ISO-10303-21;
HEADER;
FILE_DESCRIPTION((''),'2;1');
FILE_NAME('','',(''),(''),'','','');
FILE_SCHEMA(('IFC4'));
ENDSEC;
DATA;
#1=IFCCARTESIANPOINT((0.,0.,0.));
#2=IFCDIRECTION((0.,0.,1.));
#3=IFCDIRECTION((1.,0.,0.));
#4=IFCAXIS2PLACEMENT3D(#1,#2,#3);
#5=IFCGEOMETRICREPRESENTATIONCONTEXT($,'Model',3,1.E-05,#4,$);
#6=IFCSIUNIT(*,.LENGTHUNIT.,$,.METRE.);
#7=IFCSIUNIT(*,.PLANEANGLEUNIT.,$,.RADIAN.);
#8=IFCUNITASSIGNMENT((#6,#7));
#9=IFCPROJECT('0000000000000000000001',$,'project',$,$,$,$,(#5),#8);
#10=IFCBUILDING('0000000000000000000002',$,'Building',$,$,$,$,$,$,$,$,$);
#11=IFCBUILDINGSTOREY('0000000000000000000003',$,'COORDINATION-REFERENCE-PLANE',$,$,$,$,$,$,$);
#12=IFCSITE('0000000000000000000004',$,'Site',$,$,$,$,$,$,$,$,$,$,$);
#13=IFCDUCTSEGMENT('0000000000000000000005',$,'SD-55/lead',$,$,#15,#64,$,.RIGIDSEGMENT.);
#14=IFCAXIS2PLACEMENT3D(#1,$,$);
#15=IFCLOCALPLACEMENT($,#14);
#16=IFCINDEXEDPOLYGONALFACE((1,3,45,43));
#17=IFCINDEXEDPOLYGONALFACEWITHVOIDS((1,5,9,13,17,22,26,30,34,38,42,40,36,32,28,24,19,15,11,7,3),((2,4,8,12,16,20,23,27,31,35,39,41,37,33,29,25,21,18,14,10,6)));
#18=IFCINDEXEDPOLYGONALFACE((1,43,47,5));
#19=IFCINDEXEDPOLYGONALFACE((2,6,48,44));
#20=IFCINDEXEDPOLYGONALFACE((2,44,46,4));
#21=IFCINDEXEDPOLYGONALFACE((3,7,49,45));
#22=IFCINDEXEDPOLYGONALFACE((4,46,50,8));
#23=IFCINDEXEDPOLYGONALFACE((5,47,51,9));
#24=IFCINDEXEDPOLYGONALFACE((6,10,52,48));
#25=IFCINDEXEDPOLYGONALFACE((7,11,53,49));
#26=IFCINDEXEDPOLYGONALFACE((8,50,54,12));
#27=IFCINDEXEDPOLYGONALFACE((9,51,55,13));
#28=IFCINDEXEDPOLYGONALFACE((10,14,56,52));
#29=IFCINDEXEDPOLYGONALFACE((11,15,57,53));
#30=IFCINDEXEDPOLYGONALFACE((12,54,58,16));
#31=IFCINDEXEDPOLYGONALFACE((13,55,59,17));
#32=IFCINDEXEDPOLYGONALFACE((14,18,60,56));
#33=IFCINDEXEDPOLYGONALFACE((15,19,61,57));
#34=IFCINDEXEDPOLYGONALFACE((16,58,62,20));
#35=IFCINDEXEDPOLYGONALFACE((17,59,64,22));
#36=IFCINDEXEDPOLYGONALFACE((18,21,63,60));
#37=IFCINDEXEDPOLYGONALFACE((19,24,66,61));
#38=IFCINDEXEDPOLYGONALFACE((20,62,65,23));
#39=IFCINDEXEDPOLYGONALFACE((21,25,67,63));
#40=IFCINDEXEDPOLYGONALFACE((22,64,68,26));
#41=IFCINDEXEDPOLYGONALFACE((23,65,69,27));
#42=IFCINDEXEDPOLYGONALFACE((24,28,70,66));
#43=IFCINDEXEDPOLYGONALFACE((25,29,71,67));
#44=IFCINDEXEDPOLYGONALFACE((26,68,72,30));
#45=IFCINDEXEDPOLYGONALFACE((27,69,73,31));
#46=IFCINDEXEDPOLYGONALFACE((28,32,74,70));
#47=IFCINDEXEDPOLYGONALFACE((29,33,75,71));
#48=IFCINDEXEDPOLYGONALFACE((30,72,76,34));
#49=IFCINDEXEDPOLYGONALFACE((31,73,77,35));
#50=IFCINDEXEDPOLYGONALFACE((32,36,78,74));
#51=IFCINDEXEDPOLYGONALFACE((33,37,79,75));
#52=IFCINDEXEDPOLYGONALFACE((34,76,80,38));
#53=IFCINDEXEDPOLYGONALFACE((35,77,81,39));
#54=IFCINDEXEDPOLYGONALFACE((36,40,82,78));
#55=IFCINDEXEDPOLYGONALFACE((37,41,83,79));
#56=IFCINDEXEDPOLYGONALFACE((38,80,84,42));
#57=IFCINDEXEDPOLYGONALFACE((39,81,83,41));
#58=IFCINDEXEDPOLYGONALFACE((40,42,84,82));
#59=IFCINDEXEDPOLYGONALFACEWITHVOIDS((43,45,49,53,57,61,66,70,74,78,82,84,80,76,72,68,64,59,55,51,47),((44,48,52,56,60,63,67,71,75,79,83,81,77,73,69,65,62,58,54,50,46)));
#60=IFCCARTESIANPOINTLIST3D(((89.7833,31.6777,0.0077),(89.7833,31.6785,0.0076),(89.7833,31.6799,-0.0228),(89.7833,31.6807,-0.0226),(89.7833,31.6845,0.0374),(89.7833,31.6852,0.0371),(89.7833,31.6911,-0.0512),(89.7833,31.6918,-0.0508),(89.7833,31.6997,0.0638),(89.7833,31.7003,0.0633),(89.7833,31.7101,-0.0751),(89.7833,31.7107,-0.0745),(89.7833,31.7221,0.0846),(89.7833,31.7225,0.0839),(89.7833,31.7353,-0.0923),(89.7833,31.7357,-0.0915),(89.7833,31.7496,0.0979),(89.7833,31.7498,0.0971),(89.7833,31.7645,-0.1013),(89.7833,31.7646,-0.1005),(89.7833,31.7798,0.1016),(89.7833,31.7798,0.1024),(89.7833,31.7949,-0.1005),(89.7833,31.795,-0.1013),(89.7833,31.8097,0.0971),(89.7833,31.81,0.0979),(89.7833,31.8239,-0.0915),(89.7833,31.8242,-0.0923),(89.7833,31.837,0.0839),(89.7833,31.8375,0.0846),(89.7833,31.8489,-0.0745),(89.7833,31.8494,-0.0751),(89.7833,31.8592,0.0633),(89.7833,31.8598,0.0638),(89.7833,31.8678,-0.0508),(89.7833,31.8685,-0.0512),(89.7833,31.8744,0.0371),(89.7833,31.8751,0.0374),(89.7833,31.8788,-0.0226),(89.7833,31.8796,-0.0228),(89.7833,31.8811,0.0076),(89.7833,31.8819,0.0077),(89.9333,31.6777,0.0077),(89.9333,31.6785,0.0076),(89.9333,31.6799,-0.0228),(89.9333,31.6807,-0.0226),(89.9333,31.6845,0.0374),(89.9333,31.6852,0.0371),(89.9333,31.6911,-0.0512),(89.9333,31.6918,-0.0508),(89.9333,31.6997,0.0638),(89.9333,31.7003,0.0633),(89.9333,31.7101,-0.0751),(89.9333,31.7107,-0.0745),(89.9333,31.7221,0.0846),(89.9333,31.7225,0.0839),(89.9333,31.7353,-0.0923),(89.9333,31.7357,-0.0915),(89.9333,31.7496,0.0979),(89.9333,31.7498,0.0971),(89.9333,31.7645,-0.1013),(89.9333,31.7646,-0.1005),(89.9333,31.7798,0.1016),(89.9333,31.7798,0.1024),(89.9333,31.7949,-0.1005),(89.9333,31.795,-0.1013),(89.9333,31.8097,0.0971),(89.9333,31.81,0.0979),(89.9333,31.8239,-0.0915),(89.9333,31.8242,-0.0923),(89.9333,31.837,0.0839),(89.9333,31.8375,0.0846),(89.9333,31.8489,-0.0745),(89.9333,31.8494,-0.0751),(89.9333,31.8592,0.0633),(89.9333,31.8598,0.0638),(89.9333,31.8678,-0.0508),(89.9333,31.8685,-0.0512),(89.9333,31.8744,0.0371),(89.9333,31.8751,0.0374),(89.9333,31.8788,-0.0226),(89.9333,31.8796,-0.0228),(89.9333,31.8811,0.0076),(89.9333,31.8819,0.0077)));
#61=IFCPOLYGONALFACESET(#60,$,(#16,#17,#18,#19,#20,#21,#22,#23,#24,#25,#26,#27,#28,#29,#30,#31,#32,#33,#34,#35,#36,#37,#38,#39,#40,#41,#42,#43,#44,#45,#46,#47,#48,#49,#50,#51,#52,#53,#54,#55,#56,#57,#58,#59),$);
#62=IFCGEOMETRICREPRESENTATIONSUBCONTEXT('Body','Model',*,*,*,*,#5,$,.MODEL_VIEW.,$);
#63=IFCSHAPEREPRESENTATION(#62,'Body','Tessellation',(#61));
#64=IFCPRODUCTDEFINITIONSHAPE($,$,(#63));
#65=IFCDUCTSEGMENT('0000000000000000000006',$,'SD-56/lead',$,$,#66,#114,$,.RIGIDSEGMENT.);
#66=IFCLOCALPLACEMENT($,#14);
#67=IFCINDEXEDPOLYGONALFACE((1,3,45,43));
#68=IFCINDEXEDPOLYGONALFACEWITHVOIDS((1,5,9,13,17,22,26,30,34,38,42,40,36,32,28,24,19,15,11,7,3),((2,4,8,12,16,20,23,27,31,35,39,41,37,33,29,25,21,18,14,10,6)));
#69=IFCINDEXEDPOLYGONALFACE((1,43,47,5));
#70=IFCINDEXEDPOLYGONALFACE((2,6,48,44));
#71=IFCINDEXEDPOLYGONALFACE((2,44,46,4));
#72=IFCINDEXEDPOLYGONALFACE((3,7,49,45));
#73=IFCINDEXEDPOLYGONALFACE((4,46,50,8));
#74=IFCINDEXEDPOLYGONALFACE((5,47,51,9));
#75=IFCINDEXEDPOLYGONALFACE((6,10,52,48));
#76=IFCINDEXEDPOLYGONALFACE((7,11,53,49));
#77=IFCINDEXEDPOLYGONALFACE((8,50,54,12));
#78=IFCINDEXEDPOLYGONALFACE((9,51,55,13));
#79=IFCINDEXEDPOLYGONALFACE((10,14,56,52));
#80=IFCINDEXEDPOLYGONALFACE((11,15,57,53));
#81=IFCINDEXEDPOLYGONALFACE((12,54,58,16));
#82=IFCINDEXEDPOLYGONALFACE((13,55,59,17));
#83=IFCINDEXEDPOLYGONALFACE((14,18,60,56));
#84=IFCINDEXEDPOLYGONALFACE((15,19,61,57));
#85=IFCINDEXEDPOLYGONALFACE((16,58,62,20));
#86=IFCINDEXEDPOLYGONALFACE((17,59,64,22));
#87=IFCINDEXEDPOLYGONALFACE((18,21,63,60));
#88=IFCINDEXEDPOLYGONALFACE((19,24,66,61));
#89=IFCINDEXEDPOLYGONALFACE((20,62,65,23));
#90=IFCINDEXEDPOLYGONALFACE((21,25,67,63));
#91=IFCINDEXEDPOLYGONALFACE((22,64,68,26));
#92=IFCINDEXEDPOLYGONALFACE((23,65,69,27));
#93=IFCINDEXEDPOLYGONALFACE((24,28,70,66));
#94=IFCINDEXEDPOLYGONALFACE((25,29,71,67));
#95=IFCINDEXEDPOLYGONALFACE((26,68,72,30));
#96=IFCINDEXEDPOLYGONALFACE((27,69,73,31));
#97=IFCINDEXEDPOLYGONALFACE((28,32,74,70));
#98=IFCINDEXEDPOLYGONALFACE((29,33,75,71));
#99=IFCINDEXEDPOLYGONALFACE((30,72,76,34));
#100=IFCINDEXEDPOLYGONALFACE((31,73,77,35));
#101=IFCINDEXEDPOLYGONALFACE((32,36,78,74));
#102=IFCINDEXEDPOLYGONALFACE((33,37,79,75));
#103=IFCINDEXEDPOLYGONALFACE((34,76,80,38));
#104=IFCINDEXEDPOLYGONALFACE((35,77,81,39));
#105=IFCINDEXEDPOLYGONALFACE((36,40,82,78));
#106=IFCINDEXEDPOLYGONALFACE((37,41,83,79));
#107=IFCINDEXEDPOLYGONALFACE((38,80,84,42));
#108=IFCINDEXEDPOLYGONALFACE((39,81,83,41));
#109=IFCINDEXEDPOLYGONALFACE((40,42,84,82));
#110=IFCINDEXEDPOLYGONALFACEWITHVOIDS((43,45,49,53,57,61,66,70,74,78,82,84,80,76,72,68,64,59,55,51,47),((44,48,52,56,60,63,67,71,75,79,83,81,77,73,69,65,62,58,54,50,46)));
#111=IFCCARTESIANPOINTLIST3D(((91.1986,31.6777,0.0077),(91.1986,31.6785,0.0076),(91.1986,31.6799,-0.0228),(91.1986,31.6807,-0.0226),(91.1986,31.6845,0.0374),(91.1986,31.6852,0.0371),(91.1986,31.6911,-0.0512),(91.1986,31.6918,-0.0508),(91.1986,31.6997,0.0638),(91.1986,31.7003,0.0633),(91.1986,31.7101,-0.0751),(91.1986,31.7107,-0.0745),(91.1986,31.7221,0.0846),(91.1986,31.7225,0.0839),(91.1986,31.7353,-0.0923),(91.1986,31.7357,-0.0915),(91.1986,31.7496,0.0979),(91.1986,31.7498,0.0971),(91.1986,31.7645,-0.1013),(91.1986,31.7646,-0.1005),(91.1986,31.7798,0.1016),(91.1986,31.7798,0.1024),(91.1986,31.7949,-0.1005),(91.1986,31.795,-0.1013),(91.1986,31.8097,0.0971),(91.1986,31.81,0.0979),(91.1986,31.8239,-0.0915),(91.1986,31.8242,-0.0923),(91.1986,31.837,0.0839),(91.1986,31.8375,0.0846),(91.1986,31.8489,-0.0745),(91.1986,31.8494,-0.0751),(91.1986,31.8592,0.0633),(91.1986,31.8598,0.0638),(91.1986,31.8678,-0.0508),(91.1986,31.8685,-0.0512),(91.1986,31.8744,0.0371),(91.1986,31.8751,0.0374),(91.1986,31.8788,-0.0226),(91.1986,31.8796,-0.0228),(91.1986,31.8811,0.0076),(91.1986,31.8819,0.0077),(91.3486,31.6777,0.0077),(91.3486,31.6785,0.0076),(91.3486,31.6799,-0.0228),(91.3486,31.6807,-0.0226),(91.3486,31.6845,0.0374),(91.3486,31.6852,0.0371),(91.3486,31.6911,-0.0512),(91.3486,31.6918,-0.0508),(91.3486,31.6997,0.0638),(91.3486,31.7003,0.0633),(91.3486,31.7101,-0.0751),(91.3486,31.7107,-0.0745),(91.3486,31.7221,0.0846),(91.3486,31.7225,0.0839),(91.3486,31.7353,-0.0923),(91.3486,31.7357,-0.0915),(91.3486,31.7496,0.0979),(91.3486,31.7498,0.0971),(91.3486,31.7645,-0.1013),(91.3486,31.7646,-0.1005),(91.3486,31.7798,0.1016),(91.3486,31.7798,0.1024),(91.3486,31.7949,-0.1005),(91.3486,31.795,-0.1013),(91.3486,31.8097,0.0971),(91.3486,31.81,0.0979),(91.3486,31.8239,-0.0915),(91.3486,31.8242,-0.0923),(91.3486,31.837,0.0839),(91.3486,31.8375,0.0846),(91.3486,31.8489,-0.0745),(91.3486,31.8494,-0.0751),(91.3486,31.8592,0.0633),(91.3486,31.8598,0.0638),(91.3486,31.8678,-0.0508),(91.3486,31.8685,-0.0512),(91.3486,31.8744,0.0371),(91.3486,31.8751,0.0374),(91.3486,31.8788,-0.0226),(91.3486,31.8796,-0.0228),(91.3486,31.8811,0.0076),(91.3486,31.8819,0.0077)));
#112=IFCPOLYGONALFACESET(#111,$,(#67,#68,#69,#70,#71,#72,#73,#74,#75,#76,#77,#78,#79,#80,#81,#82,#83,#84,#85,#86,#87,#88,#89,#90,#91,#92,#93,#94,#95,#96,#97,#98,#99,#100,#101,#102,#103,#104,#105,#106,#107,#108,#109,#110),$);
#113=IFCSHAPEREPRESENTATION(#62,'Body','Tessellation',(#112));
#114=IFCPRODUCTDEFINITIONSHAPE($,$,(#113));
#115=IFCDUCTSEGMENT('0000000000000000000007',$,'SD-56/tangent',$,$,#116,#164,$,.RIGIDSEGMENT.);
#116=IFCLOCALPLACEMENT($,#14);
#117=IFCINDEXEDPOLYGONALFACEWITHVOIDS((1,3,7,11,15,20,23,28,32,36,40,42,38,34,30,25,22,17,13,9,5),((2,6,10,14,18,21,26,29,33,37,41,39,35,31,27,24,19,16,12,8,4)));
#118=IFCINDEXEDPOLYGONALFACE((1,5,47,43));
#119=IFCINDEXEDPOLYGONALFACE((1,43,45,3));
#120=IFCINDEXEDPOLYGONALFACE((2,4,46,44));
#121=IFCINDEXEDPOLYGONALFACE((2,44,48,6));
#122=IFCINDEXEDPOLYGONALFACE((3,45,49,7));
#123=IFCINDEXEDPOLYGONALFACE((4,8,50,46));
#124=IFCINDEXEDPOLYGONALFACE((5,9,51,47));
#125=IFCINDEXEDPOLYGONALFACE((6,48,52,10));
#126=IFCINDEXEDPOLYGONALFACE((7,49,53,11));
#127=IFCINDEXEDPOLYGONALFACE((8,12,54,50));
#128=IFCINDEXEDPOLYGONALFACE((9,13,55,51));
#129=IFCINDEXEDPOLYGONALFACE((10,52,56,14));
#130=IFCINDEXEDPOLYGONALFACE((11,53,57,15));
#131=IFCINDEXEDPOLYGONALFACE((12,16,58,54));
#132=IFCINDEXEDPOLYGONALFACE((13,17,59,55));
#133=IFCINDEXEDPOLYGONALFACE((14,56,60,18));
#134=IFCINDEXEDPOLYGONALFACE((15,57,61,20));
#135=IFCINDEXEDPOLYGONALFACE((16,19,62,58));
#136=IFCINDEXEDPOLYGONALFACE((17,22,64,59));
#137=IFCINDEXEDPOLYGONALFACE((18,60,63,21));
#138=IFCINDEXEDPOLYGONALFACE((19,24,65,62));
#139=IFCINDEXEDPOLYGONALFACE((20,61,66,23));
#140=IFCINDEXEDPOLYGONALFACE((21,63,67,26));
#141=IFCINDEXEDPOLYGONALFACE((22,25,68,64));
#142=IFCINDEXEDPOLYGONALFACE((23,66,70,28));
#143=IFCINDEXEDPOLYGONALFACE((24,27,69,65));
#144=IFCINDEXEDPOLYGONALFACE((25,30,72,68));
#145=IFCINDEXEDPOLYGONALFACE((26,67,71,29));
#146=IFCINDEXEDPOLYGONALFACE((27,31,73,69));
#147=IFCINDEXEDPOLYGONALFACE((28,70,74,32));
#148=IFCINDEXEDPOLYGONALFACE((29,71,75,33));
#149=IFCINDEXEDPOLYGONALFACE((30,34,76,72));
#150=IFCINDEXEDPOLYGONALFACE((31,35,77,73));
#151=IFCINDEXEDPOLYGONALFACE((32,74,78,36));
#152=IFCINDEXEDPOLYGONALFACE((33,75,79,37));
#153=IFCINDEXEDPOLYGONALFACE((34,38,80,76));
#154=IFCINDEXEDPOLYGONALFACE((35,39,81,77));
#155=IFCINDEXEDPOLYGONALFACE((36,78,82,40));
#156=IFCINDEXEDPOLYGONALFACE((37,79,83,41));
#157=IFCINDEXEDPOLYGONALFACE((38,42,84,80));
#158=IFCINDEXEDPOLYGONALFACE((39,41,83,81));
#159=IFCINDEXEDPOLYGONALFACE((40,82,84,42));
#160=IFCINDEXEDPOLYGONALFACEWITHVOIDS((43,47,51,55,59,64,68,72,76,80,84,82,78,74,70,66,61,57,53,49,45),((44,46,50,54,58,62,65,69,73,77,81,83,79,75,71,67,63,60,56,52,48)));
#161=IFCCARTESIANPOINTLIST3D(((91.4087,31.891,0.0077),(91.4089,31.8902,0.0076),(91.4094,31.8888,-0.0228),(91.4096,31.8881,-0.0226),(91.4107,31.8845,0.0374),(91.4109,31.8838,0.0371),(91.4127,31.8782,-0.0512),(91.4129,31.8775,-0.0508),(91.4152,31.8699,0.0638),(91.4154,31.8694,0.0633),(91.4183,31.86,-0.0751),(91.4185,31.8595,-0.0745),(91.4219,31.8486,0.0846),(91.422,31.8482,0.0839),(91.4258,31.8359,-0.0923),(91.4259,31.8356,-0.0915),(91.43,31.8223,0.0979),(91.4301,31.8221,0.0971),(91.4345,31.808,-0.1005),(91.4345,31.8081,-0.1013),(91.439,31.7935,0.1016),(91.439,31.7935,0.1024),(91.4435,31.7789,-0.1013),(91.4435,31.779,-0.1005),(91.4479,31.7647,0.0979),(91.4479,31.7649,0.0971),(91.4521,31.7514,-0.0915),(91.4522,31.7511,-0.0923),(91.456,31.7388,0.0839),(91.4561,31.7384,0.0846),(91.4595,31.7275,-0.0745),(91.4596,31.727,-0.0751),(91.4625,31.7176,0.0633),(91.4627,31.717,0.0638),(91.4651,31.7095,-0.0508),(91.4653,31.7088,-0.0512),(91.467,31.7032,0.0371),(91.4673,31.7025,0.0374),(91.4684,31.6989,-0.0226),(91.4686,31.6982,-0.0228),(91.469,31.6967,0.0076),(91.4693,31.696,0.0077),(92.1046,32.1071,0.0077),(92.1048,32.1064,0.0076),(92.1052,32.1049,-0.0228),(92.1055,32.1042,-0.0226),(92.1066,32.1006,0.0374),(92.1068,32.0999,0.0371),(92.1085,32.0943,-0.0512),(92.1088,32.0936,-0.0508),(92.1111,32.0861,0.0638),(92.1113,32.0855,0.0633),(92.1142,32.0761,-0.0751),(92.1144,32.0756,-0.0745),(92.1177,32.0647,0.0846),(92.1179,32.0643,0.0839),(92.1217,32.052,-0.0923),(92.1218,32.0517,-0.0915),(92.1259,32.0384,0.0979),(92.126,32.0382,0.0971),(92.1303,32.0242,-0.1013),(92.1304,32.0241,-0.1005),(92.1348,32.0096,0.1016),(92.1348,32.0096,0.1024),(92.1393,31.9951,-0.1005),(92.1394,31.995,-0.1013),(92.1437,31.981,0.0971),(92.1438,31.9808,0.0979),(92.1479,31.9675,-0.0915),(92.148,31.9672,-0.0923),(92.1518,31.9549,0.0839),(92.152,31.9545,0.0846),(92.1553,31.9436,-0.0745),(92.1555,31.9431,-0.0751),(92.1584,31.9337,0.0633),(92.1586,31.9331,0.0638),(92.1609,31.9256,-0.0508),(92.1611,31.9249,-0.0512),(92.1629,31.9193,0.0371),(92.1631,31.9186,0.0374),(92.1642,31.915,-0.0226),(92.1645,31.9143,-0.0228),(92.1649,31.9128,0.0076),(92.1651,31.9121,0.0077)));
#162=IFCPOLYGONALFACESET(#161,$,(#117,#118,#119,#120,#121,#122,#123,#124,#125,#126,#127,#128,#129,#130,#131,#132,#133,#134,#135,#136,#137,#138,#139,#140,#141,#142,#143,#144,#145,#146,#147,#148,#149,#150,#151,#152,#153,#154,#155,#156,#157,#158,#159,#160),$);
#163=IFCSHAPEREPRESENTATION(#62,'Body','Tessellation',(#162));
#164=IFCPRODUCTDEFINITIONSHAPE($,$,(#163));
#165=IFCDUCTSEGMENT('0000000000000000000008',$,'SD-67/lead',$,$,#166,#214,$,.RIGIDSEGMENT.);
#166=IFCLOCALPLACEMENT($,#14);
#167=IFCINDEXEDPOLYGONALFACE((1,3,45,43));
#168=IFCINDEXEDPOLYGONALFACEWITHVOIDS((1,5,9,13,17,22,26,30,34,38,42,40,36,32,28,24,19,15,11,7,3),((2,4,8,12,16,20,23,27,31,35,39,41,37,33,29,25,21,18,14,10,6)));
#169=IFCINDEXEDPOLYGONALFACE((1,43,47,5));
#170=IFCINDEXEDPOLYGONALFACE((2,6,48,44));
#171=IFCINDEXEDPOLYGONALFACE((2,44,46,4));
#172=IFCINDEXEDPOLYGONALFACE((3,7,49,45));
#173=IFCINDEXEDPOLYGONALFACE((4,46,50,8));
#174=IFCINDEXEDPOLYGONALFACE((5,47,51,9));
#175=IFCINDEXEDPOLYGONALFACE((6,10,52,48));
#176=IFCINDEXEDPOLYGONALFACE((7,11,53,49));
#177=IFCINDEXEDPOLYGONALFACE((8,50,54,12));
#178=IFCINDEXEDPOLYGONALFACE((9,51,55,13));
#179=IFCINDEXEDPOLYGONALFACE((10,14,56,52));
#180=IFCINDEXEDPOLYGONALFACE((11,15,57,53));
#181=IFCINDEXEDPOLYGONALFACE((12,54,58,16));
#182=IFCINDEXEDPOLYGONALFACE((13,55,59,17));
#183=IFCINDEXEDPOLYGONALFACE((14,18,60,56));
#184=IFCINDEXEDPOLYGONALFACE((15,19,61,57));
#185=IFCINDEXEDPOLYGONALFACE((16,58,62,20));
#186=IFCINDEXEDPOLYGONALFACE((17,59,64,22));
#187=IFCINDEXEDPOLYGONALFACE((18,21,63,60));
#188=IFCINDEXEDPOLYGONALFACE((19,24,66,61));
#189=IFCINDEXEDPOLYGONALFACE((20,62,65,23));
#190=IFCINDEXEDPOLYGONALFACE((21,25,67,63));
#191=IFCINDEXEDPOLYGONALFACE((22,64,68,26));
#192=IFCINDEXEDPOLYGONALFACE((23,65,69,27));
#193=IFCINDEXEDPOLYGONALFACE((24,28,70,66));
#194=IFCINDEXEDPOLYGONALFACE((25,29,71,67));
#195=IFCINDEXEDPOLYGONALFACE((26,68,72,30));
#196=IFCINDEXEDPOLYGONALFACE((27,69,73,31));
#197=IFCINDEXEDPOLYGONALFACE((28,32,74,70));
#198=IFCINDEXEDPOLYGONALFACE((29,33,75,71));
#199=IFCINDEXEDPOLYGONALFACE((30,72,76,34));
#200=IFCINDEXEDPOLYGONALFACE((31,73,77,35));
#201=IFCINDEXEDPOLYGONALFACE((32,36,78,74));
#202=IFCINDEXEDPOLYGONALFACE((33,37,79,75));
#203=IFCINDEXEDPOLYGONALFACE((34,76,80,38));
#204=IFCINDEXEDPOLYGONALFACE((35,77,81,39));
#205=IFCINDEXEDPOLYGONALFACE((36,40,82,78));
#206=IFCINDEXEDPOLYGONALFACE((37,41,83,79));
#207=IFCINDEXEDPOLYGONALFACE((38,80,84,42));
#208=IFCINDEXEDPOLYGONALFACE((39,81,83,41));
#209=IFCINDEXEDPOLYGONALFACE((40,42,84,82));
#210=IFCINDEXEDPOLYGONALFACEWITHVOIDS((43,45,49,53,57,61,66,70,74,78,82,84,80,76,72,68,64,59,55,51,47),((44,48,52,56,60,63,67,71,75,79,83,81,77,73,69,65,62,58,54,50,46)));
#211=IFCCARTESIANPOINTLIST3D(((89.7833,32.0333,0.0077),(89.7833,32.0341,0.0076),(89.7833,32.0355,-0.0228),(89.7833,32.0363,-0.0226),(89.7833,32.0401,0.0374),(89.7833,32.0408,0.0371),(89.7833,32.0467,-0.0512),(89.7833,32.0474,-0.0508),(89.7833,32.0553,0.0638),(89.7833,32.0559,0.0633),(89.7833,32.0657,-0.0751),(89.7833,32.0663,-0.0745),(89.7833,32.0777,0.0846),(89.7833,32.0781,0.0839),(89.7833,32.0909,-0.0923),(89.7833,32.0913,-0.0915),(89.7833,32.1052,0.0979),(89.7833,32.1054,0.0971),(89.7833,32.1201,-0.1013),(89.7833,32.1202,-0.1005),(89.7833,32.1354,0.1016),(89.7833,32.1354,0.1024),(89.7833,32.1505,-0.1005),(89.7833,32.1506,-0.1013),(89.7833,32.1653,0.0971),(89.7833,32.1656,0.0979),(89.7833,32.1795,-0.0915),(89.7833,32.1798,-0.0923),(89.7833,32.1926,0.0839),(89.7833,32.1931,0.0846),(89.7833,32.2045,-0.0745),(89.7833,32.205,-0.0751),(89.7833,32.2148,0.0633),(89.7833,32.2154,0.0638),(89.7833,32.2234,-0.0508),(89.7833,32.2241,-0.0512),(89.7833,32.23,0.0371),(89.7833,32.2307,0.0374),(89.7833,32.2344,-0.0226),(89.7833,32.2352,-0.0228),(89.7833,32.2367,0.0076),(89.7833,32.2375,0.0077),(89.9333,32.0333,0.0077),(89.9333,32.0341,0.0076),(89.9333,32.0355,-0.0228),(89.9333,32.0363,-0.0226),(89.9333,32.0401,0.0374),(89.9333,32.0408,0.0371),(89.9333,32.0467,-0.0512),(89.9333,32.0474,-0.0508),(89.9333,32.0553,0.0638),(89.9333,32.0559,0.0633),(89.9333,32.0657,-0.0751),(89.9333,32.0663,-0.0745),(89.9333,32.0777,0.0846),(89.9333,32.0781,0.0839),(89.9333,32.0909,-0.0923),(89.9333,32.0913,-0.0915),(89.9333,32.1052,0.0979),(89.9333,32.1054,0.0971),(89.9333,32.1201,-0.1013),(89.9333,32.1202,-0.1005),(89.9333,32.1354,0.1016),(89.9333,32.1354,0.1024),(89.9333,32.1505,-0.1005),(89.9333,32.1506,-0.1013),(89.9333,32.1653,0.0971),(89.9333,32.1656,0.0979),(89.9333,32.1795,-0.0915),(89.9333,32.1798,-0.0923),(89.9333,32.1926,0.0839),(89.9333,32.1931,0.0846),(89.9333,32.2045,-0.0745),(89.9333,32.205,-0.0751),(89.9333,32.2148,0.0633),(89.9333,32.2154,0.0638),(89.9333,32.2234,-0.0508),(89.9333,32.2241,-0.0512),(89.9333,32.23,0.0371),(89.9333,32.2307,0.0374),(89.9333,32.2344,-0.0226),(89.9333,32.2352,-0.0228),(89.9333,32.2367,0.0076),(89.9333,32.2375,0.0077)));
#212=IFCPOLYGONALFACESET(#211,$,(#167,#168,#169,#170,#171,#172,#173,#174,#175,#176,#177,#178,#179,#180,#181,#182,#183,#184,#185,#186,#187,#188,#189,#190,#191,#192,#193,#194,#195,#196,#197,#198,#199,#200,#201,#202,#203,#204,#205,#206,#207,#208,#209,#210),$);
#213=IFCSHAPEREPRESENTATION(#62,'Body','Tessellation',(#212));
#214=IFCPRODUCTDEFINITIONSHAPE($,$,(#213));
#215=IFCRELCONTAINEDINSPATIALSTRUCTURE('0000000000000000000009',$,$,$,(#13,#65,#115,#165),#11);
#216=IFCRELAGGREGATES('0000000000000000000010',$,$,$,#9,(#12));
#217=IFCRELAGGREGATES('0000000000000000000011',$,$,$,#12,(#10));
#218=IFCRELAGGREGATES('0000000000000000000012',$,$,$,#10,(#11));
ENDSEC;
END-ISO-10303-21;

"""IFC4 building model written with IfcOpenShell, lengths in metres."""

from ifc_helpers import new_model, si_unit, frame, origin_with_axes, place, context, subcontext, project, spatial, hollow_circle, extrude, element, save


model = new_model("IFC4")

# Units and contexts
model_context = context("Model", 3, precision=1e-05, world=origin_with_axes())
body_context_1 = subcontext(model_context, "Body", "Model", "MODEL_VIEW")
ifc_project = project(units=[si_unit("LENGTHUNIT", "METRE"), si_unit("PLANEANGLEUNIT", "RADIAN")], contexts=[model_context])

# Site, building, storey
site = spatial("IfcSite", under=ifc_project, Name="Site")
building = spatial("IfcBuilding", under=site, Name="Building")
storey = spatial("IfcBuildingStorey", under=building, Name="COORDINATION-REFERENCE-PLANE")

# Duct segments
for number, where, z_axis, x_axis, name in (
    (1, (89.9333, 31.7798, 0.0), (-1.0, 0.0, 0.0), (0.0, 0.0, 1.0), "SD-55/lead"),
    (2, (91.1986, 31.7798, 0.0), (1.0, 0.0, 0.0), (0.0, 0.0, 1.0), "SD-56/lead"),
):
    element("IfcDuctSegment", number, at=place(None, frame(where, z_axis=z_axis, x_axis=x_axis)), inside=storey, Name=name, PredefinedType="RIGIDSEGMENT", context=body_context_1, shape_type="SweptSolid", body=[
        extrude(hollow_circle(Radius=0.1024, WallThickness=0.0008), origin_with_axes(), (0.0, 0.0, 1.0), 0.15),
    ])

# Duct segment
duct_segment_1_placement = place(None, frame((91.439, 31.7935, 0.0), z_axis=(0.955005, 0.296589, 0.0), x_axis=(0.0, 0.0, 1.0)))
element("IfcDuctSegment", 3, at=duct_segment_1_placement, inside=storey, Name="SD-56/tangent", PredefinedType="RIGIDSEGMENT", context=body_context_1, shape_type="SweptSolid", body=[
    extrude(hollow_circle(Radius=0.1024, WallThickness=0.0008), origin_with_axes(), (0.0, 0.0, 1.0), 0.7286),
])

# Duct segment
duct_segment_2_placement = place(None, frame((89.9333, 32.1354, 0.0), z_axis=(-1.0, 0.0, 0.0), x_axis=(0.0, 0.0, 1.0)))
element("IfcDuctSegment", 4, at=duct_segment_2_placement, inside=storey, Name="SD-67/lead", PredefinedType="RIGIDSEGMENT", context=body_context_1, shape_type="SweptSolid", body=[
    extrude(hollow_circle(Radius=0.1024, WallThickness=0.0008), origin_with_axes(), (0.0, 0.0, 1.0), 0.15),
])

save(model, "model.ifc")
